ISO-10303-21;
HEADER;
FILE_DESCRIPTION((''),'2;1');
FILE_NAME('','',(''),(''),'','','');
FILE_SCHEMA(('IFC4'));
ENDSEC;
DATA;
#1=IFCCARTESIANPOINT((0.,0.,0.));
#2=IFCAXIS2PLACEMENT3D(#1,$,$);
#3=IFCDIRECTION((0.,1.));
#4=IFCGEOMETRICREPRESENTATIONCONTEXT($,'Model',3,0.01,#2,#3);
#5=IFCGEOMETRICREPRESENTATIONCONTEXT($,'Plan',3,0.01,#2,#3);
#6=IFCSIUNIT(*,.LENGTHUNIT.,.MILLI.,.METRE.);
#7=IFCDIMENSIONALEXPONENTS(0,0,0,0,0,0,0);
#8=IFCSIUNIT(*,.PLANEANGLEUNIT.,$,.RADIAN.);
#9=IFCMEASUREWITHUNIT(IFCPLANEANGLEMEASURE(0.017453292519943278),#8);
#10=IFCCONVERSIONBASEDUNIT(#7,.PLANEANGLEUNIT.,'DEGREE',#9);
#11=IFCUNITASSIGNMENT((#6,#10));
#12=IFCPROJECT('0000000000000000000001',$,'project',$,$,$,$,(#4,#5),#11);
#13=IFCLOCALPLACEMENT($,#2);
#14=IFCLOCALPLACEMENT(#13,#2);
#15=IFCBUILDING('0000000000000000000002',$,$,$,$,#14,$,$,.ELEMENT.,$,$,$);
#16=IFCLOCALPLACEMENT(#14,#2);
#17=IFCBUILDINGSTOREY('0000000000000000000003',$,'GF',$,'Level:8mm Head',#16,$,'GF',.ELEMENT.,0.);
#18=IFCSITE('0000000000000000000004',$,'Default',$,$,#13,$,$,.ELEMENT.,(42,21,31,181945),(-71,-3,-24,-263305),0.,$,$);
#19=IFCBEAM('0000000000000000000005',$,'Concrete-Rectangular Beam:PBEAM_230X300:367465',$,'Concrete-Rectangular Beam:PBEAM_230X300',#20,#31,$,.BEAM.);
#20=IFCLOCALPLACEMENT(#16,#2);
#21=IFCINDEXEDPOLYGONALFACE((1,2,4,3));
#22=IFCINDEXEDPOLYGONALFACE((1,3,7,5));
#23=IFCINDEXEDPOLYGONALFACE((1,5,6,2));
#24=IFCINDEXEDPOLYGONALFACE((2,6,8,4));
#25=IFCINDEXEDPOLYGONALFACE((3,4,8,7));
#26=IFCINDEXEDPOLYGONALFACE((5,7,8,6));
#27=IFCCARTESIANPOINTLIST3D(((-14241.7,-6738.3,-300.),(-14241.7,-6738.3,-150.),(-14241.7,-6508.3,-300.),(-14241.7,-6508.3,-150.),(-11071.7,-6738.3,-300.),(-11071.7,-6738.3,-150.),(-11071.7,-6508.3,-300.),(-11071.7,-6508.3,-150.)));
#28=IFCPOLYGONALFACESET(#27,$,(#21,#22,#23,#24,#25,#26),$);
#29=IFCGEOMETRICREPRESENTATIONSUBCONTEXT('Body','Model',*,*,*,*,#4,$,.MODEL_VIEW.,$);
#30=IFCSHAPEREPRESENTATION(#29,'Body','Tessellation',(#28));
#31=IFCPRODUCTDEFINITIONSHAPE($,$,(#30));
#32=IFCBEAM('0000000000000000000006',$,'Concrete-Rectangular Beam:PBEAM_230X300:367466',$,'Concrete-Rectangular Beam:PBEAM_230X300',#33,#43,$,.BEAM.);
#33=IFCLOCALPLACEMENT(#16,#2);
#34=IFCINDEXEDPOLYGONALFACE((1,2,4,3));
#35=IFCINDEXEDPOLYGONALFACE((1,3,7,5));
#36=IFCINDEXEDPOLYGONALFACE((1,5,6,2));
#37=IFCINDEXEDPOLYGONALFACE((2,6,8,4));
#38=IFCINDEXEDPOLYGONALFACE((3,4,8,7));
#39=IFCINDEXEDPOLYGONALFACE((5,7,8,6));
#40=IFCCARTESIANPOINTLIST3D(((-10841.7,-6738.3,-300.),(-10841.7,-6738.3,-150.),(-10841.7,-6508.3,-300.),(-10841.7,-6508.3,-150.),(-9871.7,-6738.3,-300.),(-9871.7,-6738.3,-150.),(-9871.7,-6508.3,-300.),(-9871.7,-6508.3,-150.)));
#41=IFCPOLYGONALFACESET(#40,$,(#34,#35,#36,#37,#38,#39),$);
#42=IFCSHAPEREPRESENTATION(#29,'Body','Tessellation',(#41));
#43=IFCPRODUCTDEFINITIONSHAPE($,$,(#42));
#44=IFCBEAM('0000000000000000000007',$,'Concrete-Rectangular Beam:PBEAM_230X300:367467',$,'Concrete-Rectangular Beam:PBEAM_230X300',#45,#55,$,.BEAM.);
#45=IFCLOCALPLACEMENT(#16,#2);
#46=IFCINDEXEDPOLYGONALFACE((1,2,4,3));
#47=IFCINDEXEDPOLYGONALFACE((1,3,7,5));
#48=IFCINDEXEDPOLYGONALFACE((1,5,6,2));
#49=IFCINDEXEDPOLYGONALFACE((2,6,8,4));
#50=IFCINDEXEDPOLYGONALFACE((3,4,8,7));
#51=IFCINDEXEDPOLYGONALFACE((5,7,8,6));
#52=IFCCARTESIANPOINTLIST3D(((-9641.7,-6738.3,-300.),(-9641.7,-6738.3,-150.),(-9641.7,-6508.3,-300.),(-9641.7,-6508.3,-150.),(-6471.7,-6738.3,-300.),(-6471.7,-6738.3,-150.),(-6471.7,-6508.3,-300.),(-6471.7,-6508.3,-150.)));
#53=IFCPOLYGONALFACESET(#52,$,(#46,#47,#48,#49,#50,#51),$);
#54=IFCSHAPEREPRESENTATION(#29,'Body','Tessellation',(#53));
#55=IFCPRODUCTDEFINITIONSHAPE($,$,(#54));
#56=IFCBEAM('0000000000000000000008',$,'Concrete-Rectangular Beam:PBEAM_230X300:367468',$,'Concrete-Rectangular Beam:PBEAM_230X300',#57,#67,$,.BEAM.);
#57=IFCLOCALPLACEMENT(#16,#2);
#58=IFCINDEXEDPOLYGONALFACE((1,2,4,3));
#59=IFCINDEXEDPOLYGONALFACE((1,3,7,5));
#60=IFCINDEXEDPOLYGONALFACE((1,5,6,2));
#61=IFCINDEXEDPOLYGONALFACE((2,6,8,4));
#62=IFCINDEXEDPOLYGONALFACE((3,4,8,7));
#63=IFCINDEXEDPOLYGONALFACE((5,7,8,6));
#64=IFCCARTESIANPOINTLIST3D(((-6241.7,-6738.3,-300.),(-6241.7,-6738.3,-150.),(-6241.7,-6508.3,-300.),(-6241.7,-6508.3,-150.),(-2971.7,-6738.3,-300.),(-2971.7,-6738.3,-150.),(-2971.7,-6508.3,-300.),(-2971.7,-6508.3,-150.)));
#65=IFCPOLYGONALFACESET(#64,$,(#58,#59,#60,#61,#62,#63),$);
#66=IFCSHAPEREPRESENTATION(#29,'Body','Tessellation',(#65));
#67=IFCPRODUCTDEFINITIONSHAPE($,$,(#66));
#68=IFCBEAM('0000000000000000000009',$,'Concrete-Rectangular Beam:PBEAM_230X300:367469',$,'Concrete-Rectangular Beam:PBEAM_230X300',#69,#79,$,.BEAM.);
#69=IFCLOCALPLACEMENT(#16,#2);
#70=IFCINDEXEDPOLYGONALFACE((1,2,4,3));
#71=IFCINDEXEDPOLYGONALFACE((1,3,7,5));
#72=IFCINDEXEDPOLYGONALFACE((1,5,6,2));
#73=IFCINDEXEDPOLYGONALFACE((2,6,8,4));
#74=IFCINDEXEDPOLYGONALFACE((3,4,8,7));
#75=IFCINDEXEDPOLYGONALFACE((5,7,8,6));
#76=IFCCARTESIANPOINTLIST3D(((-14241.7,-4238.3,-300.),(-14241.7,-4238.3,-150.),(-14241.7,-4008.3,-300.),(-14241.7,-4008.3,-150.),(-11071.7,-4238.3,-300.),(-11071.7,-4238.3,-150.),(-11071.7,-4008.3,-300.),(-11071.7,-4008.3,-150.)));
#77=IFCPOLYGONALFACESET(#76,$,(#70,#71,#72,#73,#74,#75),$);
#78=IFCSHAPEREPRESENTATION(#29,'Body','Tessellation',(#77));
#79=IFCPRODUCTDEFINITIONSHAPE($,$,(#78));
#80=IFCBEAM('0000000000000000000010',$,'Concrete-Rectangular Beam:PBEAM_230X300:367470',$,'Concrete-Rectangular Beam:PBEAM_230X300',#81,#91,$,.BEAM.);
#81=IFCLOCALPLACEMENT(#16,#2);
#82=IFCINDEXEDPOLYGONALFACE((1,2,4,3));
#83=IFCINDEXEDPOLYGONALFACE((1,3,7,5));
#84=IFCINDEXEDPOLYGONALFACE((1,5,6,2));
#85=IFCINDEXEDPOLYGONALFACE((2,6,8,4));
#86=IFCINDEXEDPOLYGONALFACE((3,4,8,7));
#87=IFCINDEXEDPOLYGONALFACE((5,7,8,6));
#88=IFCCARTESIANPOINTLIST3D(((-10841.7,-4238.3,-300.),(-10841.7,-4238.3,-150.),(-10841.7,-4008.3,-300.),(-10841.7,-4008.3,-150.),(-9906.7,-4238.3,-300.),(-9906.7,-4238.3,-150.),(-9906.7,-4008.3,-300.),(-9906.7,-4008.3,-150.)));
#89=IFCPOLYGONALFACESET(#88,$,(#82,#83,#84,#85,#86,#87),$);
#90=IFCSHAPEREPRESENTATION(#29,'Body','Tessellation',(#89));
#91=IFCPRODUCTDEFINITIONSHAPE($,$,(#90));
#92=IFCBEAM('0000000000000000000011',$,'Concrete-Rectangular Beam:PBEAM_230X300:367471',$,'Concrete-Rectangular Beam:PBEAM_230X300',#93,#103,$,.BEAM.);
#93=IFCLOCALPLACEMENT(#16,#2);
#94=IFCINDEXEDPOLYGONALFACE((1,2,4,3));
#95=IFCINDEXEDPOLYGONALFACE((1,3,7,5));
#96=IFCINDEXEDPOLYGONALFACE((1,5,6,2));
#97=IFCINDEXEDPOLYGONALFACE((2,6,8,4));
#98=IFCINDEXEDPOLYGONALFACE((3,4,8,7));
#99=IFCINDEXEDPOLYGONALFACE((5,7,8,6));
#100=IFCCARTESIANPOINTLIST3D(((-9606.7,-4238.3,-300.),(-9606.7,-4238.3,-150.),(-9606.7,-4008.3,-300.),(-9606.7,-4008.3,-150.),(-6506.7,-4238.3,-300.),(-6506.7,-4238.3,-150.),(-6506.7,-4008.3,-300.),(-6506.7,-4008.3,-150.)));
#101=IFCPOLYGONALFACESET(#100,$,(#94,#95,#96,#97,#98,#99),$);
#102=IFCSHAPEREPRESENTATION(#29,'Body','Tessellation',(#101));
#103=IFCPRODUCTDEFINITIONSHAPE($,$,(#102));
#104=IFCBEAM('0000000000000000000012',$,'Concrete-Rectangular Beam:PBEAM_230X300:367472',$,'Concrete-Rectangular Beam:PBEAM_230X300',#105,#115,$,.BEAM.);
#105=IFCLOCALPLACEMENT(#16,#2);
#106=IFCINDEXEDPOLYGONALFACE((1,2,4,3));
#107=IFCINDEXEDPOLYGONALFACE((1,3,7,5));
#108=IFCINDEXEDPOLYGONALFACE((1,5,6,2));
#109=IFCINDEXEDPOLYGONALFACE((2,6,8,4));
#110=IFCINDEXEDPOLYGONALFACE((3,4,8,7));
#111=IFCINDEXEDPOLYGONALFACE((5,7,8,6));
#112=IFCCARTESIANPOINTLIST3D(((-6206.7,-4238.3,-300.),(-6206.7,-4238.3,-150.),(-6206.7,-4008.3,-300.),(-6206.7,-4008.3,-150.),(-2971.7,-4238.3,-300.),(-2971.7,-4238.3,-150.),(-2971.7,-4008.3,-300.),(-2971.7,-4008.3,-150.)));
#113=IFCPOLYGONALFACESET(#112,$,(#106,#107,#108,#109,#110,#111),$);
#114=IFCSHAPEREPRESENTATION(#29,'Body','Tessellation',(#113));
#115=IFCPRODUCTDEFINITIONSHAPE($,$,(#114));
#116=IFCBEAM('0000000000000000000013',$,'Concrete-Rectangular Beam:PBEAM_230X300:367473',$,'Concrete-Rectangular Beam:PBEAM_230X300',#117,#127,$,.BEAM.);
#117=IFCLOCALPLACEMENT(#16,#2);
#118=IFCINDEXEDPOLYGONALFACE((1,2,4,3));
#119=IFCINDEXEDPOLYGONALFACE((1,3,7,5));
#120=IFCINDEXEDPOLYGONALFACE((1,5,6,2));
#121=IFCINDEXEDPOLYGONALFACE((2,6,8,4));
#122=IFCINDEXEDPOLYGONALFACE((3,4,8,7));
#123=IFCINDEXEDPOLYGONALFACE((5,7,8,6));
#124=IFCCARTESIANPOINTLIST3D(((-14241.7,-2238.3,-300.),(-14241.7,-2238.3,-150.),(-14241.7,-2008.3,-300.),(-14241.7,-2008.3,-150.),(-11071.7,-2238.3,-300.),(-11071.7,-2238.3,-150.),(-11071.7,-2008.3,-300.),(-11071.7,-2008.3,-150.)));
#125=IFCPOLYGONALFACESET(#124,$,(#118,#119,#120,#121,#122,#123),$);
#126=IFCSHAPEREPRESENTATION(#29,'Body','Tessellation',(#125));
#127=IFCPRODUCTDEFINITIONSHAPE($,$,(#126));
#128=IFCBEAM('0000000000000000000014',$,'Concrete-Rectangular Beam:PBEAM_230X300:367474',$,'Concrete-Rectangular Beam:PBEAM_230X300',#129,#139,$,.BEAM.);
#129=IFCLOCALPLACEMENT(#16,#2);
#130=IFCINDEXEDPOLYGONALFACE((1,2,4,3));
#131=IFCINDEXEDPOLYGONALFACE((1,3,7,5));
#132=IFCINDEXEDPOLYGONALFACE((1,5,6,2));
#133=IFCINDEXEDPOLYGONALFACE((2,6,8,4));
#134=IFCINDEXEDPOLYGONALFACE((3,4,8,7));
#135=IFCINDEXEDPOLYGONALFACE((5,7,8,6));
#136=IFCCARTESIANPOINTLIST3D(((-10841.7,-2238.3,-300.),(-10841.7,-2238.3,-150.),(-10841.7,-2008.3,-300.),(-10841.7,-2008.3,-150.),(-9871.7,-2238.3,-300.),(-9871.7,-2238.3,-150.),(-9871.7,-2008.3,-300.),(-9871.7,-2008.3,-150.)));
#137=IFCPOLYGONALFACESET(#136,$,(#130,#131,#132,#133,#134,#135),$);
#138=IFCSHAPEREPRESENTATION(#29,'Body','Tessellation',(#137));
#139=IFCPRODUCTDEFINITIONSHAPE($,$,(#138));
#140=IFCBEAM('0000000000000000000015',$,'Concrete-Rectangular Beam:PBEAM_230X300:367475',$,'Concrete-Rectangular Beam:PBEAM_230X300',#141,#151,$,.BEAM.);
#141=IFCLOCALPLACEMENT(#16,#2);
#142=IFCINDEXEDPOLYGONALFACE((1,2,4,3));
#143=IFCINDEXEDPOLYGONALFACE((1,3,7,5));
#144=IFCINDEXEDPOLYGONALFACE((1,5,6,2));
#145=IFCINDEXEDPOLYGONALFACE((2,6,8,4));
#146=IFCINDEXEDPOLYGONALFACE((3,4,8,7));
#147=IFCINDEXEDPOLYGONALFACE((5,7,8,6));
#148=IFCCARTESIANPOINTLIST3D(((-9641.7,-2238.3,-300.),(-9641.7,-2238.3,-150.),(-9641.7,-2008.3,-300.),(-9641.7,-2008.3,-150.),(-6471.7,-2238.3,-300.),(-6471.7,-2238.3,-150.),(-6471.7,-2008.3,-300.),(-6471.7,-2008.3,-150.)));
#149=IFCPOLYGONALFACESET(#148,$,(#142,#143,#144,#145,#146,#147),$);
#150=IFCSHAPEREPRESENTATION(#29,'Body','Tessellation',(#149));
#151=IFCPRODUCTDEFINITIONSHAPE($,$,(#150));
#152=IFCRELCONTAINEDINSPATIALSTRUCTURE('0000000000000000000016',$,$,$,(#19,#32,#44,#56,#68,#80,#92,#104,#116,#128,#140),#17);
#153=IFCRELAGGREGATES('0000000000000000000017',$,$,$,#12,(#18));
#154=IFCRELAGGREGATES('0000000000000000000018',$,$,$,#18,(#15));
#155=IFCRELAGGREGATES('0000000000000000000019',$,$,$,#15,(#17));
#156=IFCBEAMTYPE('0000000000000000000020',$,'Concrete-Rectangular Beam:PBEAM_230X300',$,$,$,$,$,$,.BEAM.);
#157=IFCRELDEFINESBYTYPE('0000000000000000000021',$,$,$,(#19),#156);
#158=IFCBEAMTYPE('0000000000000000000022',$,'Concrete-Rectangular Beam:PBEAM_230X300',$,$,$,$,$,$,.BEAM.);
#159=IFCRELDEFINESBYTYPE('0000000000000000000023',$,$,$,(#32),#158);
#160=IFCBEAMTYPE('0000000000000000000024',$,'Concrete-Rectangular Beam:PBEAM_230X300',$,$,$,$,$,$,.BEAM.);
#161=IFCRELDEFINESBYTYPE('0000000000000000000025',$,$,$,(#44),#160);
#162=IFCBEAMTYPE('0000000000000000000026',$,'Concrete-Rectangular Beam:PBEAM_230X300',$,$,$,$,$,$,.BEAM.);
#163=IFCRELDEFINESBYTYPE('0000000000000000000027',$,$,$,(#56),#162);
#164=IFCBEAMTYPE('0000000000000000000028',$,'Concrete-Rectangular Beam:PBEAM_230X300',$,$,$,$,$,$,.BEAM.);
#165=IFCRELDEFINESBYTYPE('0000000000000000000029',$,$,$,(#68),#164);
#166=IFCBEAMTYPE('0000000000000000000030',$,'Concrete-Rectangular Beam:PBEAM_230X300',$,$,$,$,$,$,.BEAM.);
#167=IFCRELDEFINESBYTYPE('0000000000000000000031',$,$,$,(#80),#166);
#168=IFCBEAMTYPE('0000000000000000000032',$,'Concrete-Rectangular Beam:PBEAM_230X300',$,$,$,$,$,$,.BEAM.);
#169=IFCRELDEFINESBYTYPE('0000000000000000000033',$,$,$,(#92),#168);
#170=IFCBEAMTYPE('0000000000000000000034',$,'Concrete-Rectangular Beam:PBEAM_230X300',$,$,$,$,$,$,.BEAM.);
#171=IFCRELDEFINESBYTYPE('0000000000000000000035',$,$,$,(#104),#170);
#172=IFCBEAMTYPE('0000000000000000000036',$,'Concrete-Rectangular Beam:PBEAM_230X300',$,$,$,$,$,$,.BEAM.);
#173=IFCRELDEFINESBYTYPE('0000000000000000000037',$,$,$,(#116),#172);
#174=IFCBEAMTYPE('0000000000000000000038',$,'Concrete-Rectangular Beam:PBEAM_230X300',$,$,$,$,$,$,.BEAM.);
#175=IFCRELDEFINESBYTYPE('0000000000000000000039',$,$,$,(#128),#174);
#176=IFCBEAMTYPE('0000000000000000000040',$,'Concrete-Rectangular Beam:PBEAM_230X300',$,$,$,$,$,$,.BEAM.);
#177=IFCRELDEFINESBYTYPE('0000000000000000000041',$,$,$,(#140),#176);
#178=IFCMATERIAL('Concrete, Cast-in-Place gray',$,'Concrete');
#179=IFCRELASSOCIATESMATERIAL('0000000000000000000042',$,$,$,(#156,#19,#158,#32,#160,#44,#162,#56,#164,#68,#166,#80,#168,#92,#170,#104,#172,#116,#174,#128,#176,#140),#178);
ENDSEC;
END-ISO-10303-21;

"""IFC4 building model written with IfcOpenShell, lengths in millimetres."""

from ifc_helpers import new_model, entity, si_unit, converted_unit, direction, frame, origin, place, context, subcontext, project, spatial, indexed_curve, outline, extrude, source, transform, mapped, material, type_object, type_shapes, element, save


model = new_model("IFC4")

# Units and contexts
model_context = context("Model", 3, precision=0.01, world=origin(), true_north=direction((0.0, 1.0)))
plan_context = context("Plan", 3, precision=0.01, world=origin(), true_north=direction((0.0, 1.0)))
body_context = subcontext(model_context, "Body", "Model", "MODEL_VIEW")
ifc_project = project(units=[si_unit("LENGTHUNIT", "METRE", prefix="MILLI"), converted_unit("PLANEANGLEUNIT", "DEGREE", entity("IfcPlaneAngleMeasure", 0.017453292519943278), si_unit("PLANEANGLEUNIT", "RADIAN"), dimensions=[0, 0, 0, 0, 0, 0, 0])], contexts=[model_context, plan_context])

# Site, building, storey
site_placement = place(None, origin())
site = spatial("IfcSite", under=ifc_project, at=site_placement, Name="Default", CompositionType="ELEMENT", RefLatitude=(42, 21, 31, 181945), RefLongitude=(-71, -3, -24, -263305), RefElevation=0.0)
building_placement = place(site_placement, origin())
building = spatial("IfcBuilding", under=site, at=building_placement, CompositionType="ELEMENT")
storey_placement = place(building_placement, origin())
storey = spatial("IfcBuildingStorey", under=building, at=storey_placement, Name="GF", ObjectType="Level:8mm Head", LongName="GF", CompositionType="ELEMENT", Elevation=0.0)

# Beams
ifc_material = material(Name="Concrete, Cast-in-Place gray", Category="Concrete")
beam_type_1 = type_object("IfcBeamType", Name="Concrete-Rectangular Beam:PBEAM_230X300", PredefinedType="BEAM", material=ifc_material)
shared_shape_1 = source(origin(), body_context, "Body", "SweptSolid", [
    extrude(outline(indexed_curve([(-75.0, -115.0), (75.0, -115.0), (75.0, 115.0), (-75.0, 115.0), (-75.0, -115.0)], self_intersect=False)), frame((-14241.7, -6623.3, -225.0), z_axis=(1.0, 0.0, 0.0), x_axis=(0.0, 0.0, -1.0)), (0.0, 0.0, 1.0), 3170.0),
])
type_shapes(beam_type_1, [shared_shape_1])
beam_1_placement = place(storey_placement, origin())
element("IfcBeam", 1, at=beam_1_placement, inside=storey, type_object=beam_type_1, material=ifc_material, Name="Concrete-Rectangular Beam:PBEAM_230X300:367465", ObjectType="Concrete-Rectangular Beam:PBEAM_230X300", PredefinedType="BEAM", context=body_context, shape_type="MappedRepresentation", body=[
    mapped(shared_shape_1, transform((0.0, 0.0, 0.0), scale=1.0)),
])
beam_type_2 = type_object("IfcBeamType", Name="Concrete-Rectangular Beam:PBEAM_230X300", PredefinedType="BEAM", material=ifc_material)
shared_shape_2 = source(origin(), body_context, "Body", "SweptSolid", [
    extrude(outline(indexed_curve([(-75.0, -115.0), (75.0, -115.0), (75.0, 115.0), (-75.0, 115.0), (-75.0, -115.0)], self_intersect=False)), frame((-10841.7, -6623.3, -225.0), z_axis=(1.0, 0.0, 0.0), x_axis=(0.0, 0.0, -1.0)), (0.0, 0.0, 1.0), 970.0),
])
type_shapes(beam_type_2, [shared_shape_2])
beam_2_placement = place(storey_placement, origin())
element("IfcBeam", 2, at=beam_2_placement, inside=storey, type_object=beam_type_2, material=ifc_material, Name="Concrete-Rectangular Beam:PBEAM_230X300:367466", ObjectType="Concrete-Rectangular Beam:PBEAM_230X300", PredefinedType="BEAM", context=body_context, shape_type="MappedRepresentation", body=[
    mapped(shared_shape_2, transform((0.0, 0.0, 0.0), scale=1.0)),
])
beam_type_3 = type_object("IfcBeamType", Name="Concrete-Rectangular Beam:PBEAM_230X300", PredefinedType="BEAM", material=ifc_material)
shared_shape_3 = source(origin(), body_context, "Body", "SweptSolid", [
    extrude(outline(indexed_curve([(-75.0, -115.0), (75.0, -115.0), (75.0, 115.0), (-75.0, 115.0), (-75.0, -115.0)], self_intersect=False)), frame((-9641.7, -6623.3, -225.0), z_axis=(1.0, 0.0, 0.0), x_axis=(0.0, 0.0, -1.0)), (0.0, 0.0, 1.0), 3170.0),
])
type_shapes(beam_type_3, [shared_shape_3])
beam_3_placement = place(storey_placement, origin())
element("IfcBeam", 3, at=beam_3_placement, inside=storey, type_object=beam_type_3, material=ifc_material, Name="Concrete-Rectangular Beam:PBEAM_230X300:367467", ObjectType="Concrete-Rectangular Beam:PBEAM_230X300", PredefinedType="BEAM", context=body_context, shape_type="MappedRepresentation", body=[
    mapped(shared_shape_3, transform((0.0, 0.0, 0.0), scale=1.0)),
])
beam_type_4 = type_object("IfcBeamType", Name="Concrete-Rectangular Beam:PBEAM_230X300", PredefinedType="BEAM", material=ifc_material)
shared_shape_4 = source(origin(), body_context, "Body", "SweptSolid", [
    extrude(outline(indexed_curve([(-75.0, -115.0), (75.0, -115.0), (75.0, 115.0), (-75.0, 115.0), (-75.0, -115.0)], self_intersect=False)), frame((-6241.7, -6623.3, -225.0), z_axis=(1.0, 0.0, 0.0), x_axis=(0.0, 0.0, -1.0)), (0.0, 0.0, 1.0), 3270.0),
])
type_shapes(beam_type_4, [shared_shape_4])
beam_4_placement = place(storey_placement, origin())
element("IfcBeam", 4, at=beam_4_placement, inside=storey, type_object=beam_type_4, material=ifc_material, Name="Concrete-Rectangular Beam:PBEAM_230X300:367468", ObjectType="Concrete-Rectangular Beam:PBEAM_230X300", PredefinedType="BEAM", context=body_context, shape_type="MappedRepresentation", body=[
    mapped(shared_shape_4, transform((0.0, 0.0, 0.0), scale=1.0)),
])
beam_type_5 = type_object("IfcBeamType", Name="Concrete-Rectangular Beam:PBEAM_230X300", PredefinedType="BEAM", material=ifc_material)
shared_shape_5 = source(origin(), body_context, "Body", "SweptSolid", [
    extrude(outline(indexed_curve([(-75.0, -115.0), (75.0, -115.0), (75.0, 115.0), (-75.0, 115.0), (-75.0, -115.0)], self_intersect=False)), frame((-14241.7, -4123.3, -225.0), z_axis=(1.0, 0.0, 0.0), x_axis=(0.0, 0.0, -1.0)), (0.0, 0.0, 1.0), 3170.0),
])
type_shapes(beam_type_5, [shared_shape_5])
beam_5_placement = place(storey_placement, origin())
element("IfcBeam", 5, at=beam_5_placement, inside=storey, type_object=beam_type_5, material=ifc_material, Name="Concrete-Rectangular Beam:PBEAM_230X300:367469", ObjectType="Concrete-Rectangular Beam:PBEAM_230X300", PredefinedType="BEAM", context=body_context, shape_type="MappedRepresentation", body=[
    mapped(shared_shape_5, transform((0.0, 0.0, 0.0), scale=1.0)),
])
beam_type_6 = type_object("IfcBeamType", Name="Concrete-Rectangular Beam:PBEAM_230X300", PredefinedType="BEAM", material=ifc_material)
shared_shape_6 = source(origin(), body_context, "Body", "SweptSolid", [
    extrude(outline(indexed_curve([(-75.0, -115.0), (75.0, -115.0), (75.0, 115.0), (-75.0, 115.0), (-75.0, -115.0)], self_intersect=False)), frame((-10841.7, -4123.3, -225.0), z_axis=(1.0, 0.0, 0.0), x_axis=(0.0, 0.0, -1.0)), (0.0, 0.0, 1.0), 935.0),
])
type_shapes(beam_type_6, [shared_shape_6])
beam_6_placement = place(storey_placement, origin())
element("IfcBeam", 6, at=beam_6_placement, inside=storey, type_object=beam_type_6, material=ifc_material, Name="Concrete-Rectangular Beam:PBEAM_230X300:367470", ObjectType="Concrete-Rectangular Beam:PBEAM_230X300", PredefinedType="BEAM", context=body_context, shape_type="MappedRepresentation", body=[
    mapped(shared_shape_6, transform((0.0, 0.0, 0.0), scale=1.0)),
])
beam_type_7 = type_object("IfcBeamType", Name="Concrete-Rectangular Beam:PBEAM_230X300", PredefinedType="BEAM", material=ifc_material)
shared_shape_7 = source(origin(), body_context, "Body", "SweptSolid", [
    extrude(outline(indexed_curve([(-75.0, -115.0), (75.0, -115.0), (75.0, 115.0), (-75.0, 115.0), (-75.0, -115.0)], self_intersect=False)), frame((-9606.7, -4123.3, -225.0), z_axis=(1.0, 0.0, 0.0), x_axis=(0.0, 0.0, -1.0)), (0.0, 0.0, 1.0), 3100.0),
])
type_shapes(beam_type_7, [shared_shape_7])
beam_7_placement = place(storey_placement, origin())
element("IfcBeam", 7, at=beam_7_placement, inside=storey, type_object=beam_type_7, material=ifc_material, Name="Concrete-Rectangular Beam:PBEAM_230X300:367471", ObjectType="Concrete-Rectangular Beam:PBEAM_230X300", PredefinedType="BEAM", context=body_context, shape_type="MappedRepresentation", body=[
    mapped(shared_shape_7, transform((0.0, 0.0, 0.0), scale=1.0)),
])
beam_type_8 = type_object("IfcBeamType", Name="Concrete-Rectangular Beam:PBEAM_230X300", PredefinedType="BEAM", material=ifc_material)
shared_shape_8 = source(origin(), body_context, "Body", "SweptSolid", [
    extrude(outline(indexed_curve([(-75.0, -115.0), (75.0, -115.0), (75.0, 115.0), (-75.0, 115.0), (-75.0, -115.0)], self_intersect=False)), frame((-6206.7, -4123.3, -225.0), z_axis=(1.0, 0.0, 0.0), x_axis=(0.0, 0.0, -1.0)), (0.0, 0.0, 1.0), 3235.0),
])
type_shapes(beam_type_8, [shared_shape_8])
beam_8_placement = place(storey_placement, origin())
element("IfcBeam", 8, at=beam_8_placement, inside=storey, type_object=beam_type_8, material=ifc_material, Name="Concrete-Rectangular Beam:PBEAM_230X300:367472", ObjectType="Concrete-Rectangular Beam:PBEAM_230X300", PredefinedType="BEAM", context=body_context, shape_type="MappedRepresentation", body=[
    mapped(shared_shape_8, transform((0.0, 0.0, 0.0), scale=1.0)),
])
beam_type_9 = type_object("IfcBeamType", Name="Concrete-Rectangular Beam:PBEAM_230X300", PredefinedType="BEAM", material=ifc_material)
shared_shape_9 = source(origin(), body_context, "Body", "SweptSolid", [
    extrude(outline(indexed_curve([(-75.0, -115.0), (75.0, -115.0), (75.0, 115.0), (-75.0, 115.0), (-75.0, -115.0)], self_intersect=False)), frame((-14241.7, -2123.3, -225.0), z_axis=(1.0, 0.0, 0.0), x_axis=(0.0, 0.0, -1.0)), (0.0, 0.0, 1.0), 3170.0),
])
type_shapes(beam_type_9, [shared_shape_9])
beam_9_placement = place(storey_placement, origin())
element("IfcBeam", 9, at=beam_9_placement, inside=storey, type_object=beam_type_9, material=ifc_material, Name="Concrete-Rectangular Beam:PBEAM_230X300:367473", ObjectType="Concrete-Rectangular Beam:PBEAM_230X300", PredefinedType="BEAM", context=body_context, shape_type="MappedRepresentation", body=[
    mapped(shared_shape_9, transform((0.0, 0.0, 0.0), scale=1.0)),
])
beam_type_10 = type_object("IfcBeamType", Name="Concrete-Rectangular Beam:PBEAM_230X300", PredefinedType="BEAM", material=ifc_material)
shared_shape_10 = source(origin(), body_context, "Body", "SweptSolid", [
    extrude(outline(indexed_curve([(-75.0, -115.0), (75.0, -115.0), (75.0, 115.0), (-75.0, 115.0), (-75.0, -115.0)], self_intersect=False)), frame((-10841.7, -2123.3, -225.0), z_axis=(1.0, 0.0, 0.0), x_axis=(0.0, 0.0, -1.0)), (0.0, 0.0, 1.0), 970.0),
])
type_shapes(beam_type_10, [shared_shape_10])
beam_10_placement = place(storey_placement, origin())
element("IfcBeam", 10, at=beam_10_placement, inside=storey, type_object=beam_type_10, material=ifc_material, Name="Concrete-Rectangular Beam:PBEAM_230X300:367474", ObjectType="Concrete-Rectangular Beam:PBEAM_230X300", PredefinedType="BEAM", context=body_context, shape_type="MappedRepresentation", body=[
    mapped(shared_shape_10, transform((0.0, 0.0, 0.0), scale=1.0)),
])
beam_type_11 = type_object("IfcBeamType", Name="Concrete-Rectangular Beam:PBEAM_230X300", PredefinedType="BEAM", material=ifc_material)
shared_shape_11 = source(origin(), body_context, "Body", "SweptSolid", [
    extrude(outline(indexed_curve([(-75.0, -115.0), (75.0, -115.0), (75.0, 115.0), (-75.0, 115.0), (-75.0, -115.0)], self_intersect=False)), frame((-9641.7, -2123.3, -225.0), z_axis=(1.0, 0.0, 0.0), x_axis=(0.0, 0.0, -1.0)), (0.0, 0.0, 1.0), 3170.0),
])
type_shapes(beam_type_11, [shared_shape_11])
beam_11_placement = place(storey_placement, origin())
element("IfcBeam", 11, at=beam_11_placement, inside=storey, type_object=beam_type_11, material=ifc_material, Name="Concrete-Rectangular Beam:PBEAM_230X300:367475", ObjectType="Concrete-Rectangular Beam:PBEAM_230X300", PredefinedType="BEAM", context=body_context, shape_type="MappedRepresentation", body=[
    mapped(shared_shape_11, transform((0.0, 0.0, 0.0), scale=1.0)),
])

save(model, "model.ifc")
